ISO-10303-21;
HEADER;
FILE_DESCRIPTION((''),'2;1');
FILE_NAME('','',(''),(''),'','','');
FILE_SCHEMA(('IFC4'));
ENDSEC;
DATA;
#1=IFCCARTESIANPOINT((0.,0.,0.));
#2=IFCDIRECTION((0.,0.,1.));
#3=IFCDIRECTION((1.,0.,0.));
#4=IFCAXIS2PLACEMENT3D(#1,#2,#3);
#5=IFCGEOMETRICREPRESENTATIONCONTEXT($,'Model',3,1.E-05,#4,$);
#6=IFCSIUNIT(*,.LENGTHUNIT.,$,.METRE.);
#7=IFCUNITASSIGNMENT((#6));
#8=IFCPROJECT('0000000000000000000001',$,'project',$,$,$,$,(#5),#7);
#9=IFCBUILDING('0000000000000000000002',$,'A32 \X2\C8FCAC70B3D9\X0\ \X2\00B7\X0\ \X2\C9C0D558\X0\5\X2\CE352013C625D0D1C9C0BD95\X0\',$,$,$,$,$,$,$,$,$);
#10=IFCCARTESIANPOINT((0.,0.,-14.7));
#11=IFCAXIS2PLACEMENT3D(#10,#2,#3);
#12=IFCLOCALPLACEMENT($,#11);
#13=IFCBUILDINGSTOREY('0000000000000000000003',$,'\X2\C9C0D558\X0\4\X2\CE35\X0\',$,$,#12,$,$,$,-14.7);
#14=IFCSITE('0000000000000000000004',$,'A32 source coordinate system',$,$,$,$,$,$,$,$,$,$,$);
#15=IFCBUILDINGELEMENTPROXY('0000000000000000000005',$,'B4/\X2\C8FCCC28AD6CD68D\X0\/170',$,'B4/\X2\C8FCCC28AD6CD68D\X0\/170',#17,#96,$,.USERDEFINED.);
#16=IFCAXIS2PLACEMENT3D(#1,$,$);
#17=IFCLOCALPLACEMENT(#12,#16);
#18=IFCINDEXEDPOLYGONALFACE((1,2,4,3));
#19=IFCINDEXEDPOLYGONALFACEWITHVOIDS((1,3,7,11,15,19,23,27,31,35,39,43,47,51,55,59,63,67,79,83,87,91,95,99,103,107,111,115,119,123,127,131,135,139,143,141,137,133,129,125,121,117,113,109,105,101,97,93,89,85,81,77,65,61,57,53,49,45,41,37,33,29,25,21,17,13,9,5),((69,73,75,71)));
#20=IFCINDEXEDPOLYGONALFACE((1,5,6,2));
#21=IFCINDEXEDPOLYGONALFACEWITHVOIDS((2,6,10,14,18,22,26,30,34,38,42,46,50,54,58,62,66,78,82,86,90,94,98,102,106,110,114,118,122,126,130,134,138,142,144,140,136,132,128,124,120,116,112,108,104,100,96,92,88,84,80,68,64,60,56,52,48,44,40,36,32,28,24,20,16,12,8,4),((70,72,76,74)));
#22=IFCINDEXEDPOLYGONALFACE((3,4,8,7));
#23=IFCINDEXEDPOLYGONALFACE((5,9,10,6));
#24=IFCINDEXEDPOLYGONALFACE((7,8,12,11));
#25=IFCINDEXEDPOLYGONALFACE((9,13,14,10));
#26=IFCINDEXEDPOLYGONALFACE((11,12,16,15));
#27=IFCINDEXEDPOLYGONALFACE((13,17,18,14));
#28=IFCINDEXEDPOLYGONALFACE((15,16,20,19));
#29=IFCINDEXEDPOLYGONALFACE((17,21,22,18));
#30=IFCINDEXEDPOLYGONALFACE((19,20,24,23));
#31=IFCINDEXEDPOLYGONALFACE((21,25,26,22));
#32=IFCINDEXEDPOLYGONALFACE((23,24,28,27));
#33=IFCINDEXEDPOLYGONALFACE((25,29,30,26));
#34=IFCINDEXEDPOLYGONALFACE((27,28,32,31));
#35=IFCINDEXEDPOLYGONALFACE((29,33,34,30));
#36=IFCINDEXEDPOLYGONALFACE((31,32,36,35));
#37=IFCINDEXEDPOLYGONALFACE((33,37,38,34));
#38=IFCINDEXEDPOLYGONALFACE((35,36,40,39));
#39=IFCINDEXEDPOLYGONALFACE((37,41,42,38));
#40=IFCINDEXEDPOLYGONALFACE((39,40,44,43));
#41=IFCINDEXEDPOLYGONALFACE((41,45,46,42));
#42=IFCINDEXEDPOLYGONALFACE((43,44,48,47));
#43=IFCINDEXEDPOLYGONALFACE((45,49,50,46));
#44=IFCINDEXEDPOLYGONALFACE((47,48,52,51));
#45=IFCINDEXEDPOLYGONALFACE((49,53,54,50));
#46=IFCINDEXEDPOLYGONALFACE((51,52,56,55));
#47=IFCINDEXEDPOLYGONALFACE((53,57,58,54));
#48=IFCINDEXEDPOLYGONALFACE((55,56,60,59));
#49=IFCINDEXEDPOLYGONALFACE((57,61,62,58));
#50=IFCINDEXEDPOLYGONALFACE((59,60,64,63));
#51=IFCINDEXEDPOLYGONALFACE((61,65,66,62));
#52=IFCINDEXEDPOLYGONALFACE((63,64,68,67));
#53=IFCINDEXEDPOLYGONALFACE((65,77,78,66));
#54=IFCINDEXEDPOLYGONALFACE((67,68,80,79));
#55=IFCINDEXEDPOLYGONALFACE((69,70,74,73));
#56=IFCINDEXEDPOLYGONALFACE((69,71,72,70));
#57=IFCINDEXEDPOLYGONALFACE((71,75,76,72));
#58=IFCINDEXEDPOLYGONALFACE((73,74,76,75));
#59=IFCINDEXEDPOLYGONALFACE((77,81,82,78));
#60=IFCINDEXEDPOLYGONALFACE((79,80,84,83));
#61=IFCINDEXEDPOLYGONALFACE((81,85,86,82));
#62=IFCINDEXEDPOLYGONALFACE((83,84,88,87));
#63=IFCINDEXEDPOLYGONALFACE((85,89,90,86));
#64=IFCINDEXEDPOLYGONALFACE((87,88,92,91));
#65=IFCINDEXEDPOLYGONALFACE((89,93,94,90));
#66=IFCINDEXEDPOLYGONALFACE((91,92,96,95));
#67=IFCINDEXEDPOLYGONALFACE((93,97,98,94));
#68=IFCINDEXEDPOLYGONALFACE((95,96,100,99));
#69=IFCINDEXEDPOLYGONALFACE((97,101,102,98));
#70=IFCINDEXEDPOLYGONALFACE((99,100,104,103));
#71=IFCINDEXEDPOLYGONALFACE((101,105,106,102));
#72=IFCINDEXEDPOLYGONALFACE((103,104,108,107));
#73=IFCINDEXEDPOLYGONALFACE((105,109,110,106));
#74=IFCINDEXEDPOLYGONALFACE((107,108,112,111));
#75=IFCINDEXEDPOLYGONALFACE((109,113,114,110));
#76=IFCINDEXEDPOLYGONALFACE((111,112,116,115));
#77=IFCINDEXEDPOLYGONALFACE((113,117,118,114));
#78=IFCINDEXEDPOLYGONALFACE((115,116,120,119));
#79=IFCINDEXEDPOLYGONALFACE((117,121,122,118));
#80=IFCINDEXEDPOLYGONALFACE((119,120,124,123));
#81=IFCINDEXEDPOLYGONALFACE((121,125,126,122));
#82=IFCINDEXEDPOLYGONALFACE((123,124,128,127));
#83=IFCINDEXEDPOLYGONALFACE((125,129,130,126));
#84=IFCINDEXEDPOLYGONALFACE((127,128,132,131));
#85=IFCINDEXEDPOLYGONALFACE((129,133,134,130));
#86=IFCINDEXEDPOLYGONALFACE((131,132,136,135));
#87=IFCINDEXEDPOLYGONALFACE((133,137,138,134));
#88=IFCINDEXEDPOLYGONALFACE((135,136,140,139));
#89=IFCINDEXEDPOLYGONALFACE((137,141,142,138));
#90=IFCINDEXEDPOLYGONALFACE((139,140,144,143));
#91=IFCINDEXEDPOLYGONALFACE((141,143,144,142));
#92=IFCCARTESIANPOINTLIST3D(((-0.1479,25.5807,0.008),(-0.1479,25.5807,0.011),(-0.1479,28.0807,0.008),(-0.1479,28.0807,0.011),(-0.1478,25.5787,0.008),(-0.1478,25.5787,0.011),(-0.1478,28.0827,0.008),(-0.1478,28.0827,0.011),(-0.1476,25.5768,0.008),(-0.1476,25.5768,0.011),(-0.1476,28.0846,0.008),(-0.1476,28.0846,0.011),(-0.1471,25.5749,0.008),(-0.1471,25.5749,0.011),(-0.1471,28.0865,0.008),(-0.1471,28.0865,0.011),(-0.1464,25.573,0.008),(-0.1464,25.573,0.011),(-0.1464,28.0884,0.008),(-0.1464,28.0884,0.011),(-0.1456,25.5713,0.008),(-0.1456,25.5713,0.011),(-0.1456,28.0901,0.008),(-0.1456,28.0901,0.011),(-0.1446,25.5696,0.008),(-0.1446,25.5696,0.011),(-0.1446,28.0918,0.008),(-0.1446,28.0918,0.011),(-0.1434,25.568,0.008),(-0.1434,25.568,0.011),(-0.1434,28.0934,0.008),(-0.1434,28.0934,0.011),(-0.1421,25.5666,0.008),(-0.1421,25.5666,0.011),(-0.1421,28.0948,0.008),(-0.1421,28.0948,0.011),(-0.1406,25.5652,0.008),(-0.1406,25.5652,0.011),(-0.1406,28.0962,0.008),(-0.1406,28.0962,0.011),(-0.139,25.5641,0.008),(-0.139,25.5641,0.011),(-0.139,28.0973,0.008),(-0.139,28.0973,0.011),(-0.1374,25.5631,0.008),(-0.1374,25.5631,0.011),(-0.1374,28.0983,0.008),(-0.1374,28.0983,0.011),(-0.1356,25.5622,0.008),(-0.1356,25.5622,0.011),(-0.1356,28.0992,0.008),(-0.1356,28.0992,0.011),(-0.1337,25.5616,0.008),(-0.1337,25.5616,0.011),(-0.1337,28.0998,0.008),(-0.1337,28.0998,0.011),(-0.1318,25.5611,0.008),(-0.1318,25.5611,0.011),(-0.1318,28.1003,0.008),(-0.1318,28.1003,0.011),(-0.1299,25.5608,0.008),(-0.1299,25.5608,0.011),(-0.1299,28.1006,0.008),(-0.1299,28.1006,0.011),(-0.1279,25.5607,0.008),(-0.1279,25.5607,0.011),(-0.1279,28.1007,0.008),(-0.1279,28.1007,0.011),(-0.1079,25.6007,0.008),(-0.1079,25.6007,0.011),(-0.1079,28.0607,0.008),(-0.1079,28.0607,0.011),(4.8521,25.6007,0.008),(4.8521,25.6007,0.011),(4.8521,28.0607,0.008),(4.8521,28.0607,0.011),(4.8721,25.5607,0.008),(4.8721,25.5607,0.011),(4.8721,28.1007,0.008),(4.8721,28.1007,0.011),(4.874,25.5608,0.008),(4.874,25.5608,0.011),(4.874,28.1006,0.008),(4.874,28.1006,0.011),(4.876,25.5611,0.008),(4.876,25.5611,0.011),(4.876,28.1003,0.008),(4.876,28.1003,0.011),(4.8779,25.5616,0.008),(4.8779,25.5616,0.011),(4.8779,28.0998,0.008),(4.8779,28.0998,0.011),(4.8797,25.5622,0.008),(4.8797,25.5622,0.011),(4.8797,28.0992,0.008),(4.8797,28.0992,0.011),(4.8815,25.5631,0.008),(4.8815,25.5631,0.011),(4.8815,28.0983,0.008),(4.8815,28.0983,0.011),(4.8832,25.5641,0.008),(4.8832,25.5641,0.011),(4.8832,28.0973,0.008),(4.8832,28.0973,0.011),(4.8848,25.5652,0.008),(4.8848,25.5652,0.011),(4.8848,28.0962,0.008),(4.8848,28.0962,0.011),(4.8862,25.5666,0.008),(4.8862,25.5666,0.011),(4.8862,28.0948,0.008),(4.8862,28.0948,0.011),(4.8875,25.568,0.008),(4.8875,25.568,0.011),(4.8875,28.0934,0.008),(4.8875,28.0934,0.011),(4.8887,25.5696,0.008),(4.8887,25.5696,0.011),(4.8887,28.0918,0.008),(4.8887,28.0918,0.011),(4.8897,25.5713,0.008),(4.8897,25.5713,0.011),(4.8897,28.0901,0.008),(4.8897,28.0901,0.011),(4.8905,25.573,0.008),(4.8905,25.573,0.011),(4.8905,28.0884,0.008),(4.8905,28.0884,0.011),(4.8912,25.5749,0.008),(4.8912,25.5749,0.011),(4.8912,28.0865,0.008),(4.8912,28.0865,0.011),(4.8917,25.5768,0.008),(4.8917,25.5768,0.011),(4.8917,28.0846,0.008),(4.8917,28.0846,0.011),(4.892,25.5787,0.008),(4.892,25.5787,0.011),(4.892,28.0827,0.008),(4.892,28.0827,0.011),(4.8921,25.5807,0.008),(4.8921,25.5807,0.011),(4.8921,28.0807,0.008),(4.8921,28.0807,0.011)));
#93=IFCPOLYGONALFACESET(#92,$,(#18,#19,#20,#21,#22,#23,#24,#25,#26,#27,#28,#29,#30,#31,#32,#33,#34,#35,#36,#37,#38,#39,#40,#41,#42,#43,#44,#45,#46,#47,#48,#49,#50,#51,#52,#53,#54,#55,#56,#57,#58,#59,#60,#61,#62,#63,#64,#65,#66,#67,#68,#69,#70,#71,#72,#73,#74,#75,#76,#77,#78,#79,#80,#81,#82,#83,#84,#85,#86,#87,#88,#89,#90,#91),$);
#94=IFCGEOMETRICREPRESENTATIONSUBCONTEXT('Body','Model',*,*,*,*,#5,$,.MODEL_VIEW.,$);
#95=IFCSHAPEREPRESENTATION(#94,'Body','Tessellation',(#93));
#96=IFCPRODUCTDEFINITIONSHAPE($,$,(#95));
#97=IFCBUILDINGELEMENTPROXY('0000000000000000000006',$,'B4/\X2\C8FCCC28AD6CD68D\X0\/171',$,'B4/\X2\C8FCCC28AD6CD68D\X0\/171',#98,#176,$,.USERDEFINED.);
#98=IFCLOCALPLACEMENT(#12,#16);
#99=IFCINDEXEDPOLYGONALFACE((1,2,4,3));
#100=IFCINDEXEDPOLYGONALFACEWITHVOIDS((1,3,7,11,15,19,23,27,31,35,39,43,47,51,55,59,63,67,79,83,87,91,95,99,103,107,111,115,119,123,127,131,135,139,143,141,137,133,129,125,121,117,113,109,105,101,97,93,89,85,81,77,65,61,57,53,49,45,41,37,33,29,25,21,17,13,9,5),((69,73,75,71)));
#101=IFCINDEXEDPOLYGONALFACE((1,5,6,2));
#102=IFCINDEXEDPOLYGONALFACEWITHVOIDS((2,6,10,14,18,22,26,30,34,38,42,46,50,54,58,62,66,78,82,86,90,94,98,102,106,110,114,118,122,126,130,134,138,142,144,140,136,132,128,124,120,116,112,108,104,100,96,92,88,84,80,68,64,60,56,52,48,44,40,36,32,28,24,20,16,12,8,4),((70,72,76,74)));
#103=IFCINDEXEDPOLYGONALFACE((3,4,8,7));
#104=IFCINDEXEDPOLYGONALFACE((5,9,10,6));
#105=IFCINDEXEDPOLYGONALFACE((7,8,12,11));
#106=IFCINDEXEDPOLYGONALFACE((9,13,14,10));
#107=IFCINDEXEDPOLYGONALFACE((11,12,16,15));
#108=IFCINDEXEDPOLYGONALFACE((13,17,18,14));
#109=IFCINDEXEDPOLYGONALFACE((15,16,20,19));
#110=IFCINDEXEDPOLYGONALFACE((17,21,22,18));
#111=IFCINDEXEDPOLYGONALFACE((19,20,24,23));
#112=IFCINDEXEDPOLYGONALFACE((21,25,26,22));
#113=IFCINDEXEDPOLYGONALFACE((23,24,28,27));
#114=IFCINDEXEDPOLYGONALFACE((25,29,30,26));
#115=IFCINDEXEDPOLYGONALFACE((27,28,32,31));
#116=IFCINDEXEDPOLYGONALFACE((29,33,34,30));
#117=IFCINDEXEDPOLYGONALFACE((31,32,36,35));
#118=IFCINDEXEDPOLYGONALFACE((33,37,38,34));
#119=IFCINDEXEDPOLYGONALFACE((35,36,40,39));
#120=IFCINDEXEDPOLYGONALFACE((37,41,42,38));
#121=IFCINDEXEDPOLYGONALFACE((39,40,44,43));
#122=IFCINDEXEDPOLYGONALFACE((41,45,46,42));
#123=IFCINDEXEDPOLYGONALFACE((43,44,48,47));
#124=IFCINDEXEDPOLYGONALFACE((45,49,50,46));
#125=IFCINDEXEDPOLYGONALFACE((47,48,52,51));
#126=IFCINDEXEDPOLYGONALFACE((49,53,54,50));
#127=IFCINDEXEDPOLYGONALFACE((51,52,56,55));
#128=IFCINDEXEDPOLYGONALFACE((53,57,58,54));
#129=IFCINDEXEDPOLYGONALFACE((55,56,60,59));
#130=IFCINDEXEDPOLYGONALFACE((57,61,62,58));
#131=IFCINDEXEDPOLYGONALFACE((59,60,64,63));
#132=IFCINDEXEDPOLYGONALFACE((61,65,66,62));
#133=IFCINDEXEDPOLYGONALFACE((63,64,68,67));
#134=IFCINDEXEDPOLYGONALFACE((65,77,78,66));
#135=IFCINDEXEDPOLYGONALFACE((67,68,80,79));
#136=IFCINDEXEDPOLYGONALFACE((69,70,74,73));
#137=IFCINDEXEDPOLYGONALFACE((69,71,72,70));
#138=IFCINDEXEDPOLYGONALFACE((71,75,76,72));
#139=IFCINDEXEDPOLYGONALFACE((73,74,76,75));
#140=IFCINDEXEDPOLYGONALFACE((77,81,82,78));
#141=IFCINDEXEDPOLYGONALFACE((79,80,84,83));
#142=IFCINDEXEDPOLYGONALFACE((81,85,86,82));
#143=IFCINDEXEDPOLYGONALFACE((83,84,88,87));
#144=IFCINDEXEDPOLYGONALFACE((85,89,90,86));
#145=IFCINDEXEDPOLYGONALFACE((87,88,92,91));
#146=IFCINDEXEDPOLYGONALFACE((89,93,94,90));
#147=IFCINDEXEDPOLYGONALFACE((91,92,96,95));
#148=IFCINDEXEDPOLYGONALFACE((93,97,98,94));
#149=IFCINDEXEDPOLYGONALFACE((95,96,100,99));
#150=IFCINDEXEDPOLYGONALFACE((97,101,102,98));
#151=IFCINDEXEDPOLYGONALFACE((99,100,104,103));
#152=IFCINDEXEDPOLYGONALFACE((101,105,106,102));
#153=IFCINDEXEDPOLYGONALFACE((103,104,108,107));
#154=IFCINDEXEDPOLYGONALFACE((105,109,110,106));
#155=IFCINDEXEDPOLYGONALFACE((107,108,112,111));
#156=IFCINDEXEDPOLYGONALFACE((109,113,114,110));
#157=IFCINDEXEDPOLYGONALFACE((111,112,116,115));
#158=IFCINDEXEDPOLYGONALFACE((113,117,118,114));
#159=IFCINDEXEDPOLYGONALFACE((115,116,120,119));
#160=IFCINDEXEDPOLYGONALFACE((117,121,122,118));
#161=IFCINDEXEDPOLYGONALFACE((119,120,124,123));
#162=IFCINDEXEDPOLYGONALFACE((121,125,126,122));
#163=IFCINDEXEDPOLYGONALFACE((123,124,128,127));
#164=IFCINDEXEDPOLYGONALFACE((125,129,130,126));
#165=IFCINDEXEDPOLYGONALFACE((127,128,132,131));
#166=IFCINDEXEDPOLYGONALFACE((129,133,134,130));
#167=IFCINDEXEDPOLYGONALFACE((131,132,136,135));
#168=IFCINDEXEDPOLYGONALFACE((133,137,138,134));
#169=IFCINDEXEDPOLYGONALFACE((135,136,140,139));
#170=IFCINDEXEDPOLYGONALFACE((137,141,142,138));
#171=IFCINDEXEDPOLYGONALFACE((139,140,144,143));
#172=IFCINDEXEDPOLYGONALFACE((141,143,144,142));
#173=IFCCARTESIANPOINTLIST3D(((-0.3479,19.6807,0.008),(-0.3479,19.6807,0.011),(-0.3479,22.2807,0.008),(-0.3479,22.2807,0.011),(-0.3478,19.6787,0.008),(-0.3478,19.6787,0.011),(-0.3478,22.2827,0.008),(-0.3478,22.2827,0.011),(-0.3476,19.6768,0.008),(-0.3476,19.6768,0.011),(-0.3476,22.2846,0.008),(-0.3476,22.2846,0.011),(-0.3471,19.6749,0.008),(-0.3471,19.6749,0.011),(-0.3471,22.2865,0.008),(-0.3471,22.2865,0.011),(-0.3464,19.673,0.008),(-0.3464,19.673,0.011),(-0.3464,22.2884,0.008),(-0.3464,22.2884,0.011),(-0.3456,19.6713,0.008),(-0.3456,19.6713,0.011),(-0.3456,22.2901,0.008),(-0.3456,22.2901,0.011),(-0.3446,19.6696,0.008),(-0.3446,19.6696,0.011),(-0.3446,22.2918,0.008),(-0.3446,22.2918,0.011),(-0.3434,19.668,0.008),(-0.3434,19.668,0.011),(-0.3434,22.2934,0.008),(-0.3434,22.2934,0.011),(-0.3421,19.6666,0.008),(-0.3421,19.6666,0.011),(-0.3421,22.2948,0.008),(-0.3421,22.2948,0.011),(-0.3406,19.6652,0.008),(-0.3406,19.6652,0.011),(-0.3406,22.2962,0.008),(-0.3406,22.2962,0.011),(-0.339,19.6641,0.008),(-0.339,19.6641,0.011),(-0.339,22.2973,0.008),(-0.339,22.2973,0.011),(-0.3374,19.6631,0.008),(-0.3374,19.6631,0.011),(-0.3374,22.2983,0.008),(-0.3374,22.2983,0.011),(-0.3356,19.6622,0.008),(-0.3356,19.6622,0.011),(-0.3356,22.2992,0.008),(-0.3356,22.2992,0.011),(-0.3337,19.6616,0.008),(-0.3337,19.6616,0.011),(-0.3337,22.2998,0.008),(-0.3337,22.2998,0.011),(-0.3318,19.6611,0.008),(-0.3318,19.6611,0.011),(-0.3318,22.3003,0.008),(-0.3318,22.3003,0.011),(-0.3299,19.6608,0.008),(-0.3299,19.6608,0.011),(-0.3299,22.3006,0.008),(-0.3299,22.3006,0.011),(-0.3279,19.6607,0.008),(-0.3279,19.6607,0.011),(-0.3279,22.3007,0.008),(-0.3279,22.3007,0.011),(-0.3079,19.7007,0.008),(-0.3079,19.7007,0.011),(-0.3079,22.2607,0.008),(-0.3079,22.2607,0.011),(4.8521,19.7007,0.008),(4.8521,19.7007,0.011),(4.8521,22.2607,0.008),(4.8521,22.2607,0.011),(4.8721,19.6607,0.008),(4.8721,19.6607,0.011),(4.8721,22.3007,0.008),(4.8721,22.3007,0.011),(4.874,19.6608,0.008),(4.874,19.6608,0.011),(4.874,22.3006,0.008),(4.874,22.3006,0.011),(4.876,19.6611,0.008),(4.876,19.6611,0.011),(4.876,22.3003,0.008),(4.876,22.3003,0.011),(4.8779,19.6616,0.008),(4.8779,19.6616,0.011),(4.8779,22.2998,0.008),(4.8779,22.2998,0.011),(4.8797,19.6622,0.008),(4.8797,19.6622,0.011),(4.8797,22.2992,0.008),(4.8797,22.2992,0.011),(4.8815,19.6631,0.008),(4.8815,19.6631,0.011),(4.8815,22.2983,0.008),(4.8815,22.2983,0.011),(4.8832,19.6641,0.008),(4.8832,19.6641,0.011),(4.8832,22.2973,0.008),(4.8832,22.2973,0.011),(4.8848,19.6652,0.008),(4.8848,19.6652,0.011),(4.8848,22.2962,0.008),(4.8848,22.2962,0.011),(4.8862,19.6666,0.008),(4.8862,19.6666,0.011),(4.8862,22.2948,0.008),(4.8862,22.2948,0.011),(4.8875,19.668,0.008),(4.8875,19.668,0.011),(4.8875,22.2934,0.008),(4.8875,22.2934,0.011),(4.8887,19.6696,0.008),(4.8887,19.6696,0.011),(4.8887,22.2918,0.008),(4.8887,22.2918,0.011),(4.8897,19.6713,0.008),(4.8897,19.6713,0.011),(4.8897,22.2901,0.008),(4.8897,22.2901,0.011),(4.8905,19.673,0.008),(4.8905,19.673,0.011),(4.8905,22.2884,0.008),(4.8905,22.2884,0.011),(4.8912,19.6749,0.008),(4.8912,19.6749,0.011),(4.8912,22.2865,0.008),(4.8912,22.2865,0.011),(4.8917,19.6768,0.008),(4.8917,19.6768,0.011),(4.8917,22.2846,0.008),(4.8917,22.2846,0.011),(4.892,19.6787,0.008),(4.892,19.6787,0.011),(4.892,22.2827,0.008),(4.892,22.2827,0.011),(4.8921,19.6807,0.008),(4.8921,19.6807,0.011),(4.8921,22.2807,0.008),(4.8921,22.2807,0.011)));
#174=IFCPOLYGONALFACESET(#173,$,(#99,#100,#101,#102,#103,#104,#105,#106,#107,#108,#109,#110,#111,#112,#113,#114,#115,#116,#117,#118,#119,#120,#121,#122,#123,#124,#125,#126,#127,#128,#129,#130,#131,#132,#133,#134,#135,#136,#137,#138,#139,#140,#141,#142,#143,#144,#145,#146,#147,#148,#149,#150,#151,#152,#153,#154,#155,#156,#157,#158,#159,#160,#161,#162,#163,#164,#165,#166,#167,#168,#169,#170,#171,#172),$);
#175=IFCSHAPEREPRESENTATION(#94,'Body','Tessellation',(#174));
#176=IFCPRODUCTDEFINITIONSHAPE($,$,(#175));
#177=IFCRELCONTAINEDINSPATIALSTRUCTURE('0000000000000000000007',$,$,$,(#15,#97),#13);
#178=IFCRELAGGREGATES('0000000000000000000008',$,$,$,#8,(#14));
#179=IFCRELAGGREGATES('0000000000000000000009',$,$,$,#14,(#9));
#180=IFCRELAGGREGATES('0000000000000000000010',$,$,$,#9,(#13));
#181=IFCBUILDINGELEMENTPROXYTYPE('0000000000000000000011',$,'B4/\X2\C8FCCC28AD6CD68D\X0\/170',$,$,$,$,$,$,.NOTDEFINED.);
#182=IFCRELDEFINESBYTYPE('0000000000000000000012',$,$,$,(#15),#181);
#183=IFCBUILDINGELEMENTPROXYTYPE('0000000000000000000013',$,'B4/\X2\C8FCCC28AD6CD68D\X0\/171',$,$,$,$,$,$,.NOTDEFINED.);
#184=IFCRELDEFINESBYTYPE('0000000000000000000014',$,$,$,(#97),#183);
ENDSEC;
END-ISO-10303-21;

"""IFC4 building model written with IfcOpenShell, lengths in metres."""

from ifc_helpers import new_model, si_unit, frame, origin, origin_with_axes, place, context, subcontext, project, spatial, polyline, outline, extrude, source, transform, mapped, type_object, type_shapes, element, save


model = new_model("IFC4")

# Units and contexts
model_context = context("Model", 3, precision=1e-05, world=origin_with_axes())
body_context = subcontext(model_context, "Body", "Model", "MODEL_VIEW")
ifc_project = project(units=[si_unit("LENGTHUNIT", "METRE")], contexts=[model_context])

# Site, building, storey
site = spatial("IfcSite", under=ifc_project, Name="A32 source coordinate system")
building = spatial("IfcBuilding", under=site, Name="A32 주거동 · 지하5층–옥탑지붕")
storey_placement = place(None, frame((0.0, 0.0, -14.7), z_axis=(0.0, 0.0, 1.0), x_axis=(1.0, 0.0, 0.0)))
storey = spatial("IfcBuildingStorey", under=building, at=storey_placement, Name="지하4층", Elevation=-14.7)

# Building element proxies
building_element_proxy_type_1 = type_object("IfcBuildingElementProxyType", Name="B4/주차구획/170", PredefinedType="NOTDEFINED")
shared_shape_1 = source(origin(), body_context, "Body", "SweptSolid", [
    extrude(outline(polyline([(-0.1279, 25.5607), (-0.1299, 25.5608), (-0.1318, 25.5611), (-0.1337, 25.5616), (-0.1356, 25.5622), (-0.1374, 25.5631), (-0.139, 25.5641), (-0.1406, 25.5652), (-0.1421, 25.5666), (-0.1434, 25.568), (-0.1446, 25.5696), (-0.1456, 25.5713), (-0.1464, 25.573), (-0.1471, 25.5749), (-0.1476, 25.5768), (-0.1478, 25.5787), (-0.1479, 25.5807), (-0.1479, 28.0807), (-0.1478, 28.0827), (-0.1476, 28.0846), (-0.1471, 28.0865), (-0.1464, 28.0884), (-0.1456, 28.0901), (-0.1446, 28.0918), (-0.1434, 28.0934), (-0.1421, 28.0948), (-0.1406, 28.0962), (-0.139, 28.0973), (-0.1374, 28.0983), (-0.1356, 28.0992), (-0.1337, 28.0998), (-0.1318, 28.1003), (-0.1299, 28.1006), (-0.1279, 28.1007), (4.8721, 28.1007), (4.874, 28.1006), (4.876, 28.1003), (4.8779, 28.0998), (4.8797, 28.0992), (4.8815, 28.0983), (4.8832, 28.0973), (4.8848, 28.0962), (4.8862, 28.0948), (4.8875, 28.0934), (4.8887, 28.0918), (4.8897, 28.0901), (4.8905, 28.0884), (4.8912, 28.0865), (4.8917, 28.0846), (4.892, 28.0827), (4.8921, 28.0807), (4.8921, 25.5807), (4.892, 25.5787), (4.8917, 25.5768), (4.8912, 25.5749), (4.8905, 25.573), (4.8897, 25.5713), (4.8887, 25.5696), (4.8875, 25.568), (4.8862, 25.5666), (4.8848, 25.5652), (4.8832, 25.5641), (4.8815, 25.5631), (4.8797, 25.5622), (4.8779, 25.5616), (4.876, 25.5611), (4.874, 25.5608), (4.8721, 25.5607), (-0.1279, 25.5607)]), holes=[polyline([(-0.1079, 25.6007), (4.8521, 25.6007), (4.8521, 28.0607), (-0.1079, 28.0607), (-0.1079, 25.6007)])]), frame((0.0, 0.0, 0.008)), (0.0, 0.0, 1.0), 0.003),
])
type_shapes(building_element_proxy_type_1, [shared_shape_1])
proxy_1_placement = place(storey_placement, origin_with_axes())
element("IfcBuildingElementProxy", 1, at=proxy_1_placement, inside=storey, type_object=building_element_proxy_type_1, Name="B4/주차구획/170", ObjectType="B4/주차구획/170", PredefinedType="USERDEFINED", context=body_context, shape_type="MappedRepresentation", body=[
    mapped(shared_shape_1, transform((0.0, 0.0, 0.0), scale=1.0)),
])
building_element_proxy_type_2 = type_object("IfcBuildingElementProxyType", Name="B4/주차구획/171", PredefinedType="NOTDEFINED")
shared_shape_2 = source(origin(), body_context, "Body", "SweptSolid", [
    extrude(outline(polyline([(-0.3279, 19.6607), (-0.3299, 19.6608), (-0.3318, 19.6611), (-0.3337, 19.6616), (-0.3356, 19.6622), (-0.3374, 19.6631), (-0.339, 19.6641), (-0.3406, 19.6652), (-0.3421, 19.6666), (-0.3434, 19.668), (-0.3446, 19.6696), (-0.3456, 19.6713), (-0.3464, 19.673), (-0.3471, 19.6749), (-0.3476, 19.6768), (-0.3478, 19.6787), (-0.3479, 19.6807), (-0.3479, 22.2807), (-0.3478, 22.2827), (-0.3476, 22.2846), (-0.3471, 22.2865), (-0.3464, 22.2884), (-0.3456, 22.2901), (-0.3446, 22.2918), (-0.3434, 22.2934), (-0.3421, 22.2948), (-0.3406, 22.2962), (-0.339, 22.2973), (-0.3374, 22.2983), (-0.3356, 22.2992), (-0.3337, 22.2998), (-0.3318, 22.3003), (-0.3299, 22.3006), (-0.3279, 22.3007), (4.8721, 22.3007), (4.874, 22.3006), (4.876, 22.3003), (4.8779, 22.2998), (4.8797, 22.2992), (4.8815, 22.2983), (4.8832, 22.2973), (4.8848, 22.2962), (4.8862, 22.2948), (4.8875, 22.2934), (4.8887, 22.2918), (4.8897, 22.2901), (4.8905, 22.2884), (4.8912, 22.2865), (4.8917, 22.2846), (4.892, 22.2827), (4.8921, 22.2807), (4.8921, 19.6807), (4.892, 19.6787), (4.8917, 19.6768), (4.8912, 19.6749), (4.8905, 19.673), (4.8897, 19.6713), (4.8887, 19.6696), (4.8875, 19.668), (4.8862, 19.6666), (4.8848, 19.6652), (4.8832, 19.6641), (4.8815, 19.6631), (4.8797, 19.6622), (4.8779, 19.6616), (4.876, 19.6611), (4.874, 19.6608), (4.8721, 19.6607), (-0.3279, 19.6607)]), holes=[polyline([(-0.3079, 19.7007), (4.8521, 19.7007), (4.8521, 22.2607), (-0.3079, 22.2607), (-0.3079, 19.7007)])]), frame((0.0, 0.0, 0.008)), (0.0, 0.0, 1.0), 0.003),
])
type_shapes(building_element_proxy_type_2, [shared_shape_2])
proxy_2_placement = place(storey_placement, origin_with_axes())
element("IfcBuildingElementProxy", 2, at=proxy_2_placement, inside=storey, type_object=building_element_proxy_type_2, Name="B4/주차구획/171", ObjectType="B4/주차구획/171", PredefinedType="USERDEFINED", context=body_context, shape_type="MappedRepresentation", body=[
    mapped(shared_shape_2, transform((0.0, 0.0, 0.0), scale=1.0)),
])

save(model, "model.ifc")
